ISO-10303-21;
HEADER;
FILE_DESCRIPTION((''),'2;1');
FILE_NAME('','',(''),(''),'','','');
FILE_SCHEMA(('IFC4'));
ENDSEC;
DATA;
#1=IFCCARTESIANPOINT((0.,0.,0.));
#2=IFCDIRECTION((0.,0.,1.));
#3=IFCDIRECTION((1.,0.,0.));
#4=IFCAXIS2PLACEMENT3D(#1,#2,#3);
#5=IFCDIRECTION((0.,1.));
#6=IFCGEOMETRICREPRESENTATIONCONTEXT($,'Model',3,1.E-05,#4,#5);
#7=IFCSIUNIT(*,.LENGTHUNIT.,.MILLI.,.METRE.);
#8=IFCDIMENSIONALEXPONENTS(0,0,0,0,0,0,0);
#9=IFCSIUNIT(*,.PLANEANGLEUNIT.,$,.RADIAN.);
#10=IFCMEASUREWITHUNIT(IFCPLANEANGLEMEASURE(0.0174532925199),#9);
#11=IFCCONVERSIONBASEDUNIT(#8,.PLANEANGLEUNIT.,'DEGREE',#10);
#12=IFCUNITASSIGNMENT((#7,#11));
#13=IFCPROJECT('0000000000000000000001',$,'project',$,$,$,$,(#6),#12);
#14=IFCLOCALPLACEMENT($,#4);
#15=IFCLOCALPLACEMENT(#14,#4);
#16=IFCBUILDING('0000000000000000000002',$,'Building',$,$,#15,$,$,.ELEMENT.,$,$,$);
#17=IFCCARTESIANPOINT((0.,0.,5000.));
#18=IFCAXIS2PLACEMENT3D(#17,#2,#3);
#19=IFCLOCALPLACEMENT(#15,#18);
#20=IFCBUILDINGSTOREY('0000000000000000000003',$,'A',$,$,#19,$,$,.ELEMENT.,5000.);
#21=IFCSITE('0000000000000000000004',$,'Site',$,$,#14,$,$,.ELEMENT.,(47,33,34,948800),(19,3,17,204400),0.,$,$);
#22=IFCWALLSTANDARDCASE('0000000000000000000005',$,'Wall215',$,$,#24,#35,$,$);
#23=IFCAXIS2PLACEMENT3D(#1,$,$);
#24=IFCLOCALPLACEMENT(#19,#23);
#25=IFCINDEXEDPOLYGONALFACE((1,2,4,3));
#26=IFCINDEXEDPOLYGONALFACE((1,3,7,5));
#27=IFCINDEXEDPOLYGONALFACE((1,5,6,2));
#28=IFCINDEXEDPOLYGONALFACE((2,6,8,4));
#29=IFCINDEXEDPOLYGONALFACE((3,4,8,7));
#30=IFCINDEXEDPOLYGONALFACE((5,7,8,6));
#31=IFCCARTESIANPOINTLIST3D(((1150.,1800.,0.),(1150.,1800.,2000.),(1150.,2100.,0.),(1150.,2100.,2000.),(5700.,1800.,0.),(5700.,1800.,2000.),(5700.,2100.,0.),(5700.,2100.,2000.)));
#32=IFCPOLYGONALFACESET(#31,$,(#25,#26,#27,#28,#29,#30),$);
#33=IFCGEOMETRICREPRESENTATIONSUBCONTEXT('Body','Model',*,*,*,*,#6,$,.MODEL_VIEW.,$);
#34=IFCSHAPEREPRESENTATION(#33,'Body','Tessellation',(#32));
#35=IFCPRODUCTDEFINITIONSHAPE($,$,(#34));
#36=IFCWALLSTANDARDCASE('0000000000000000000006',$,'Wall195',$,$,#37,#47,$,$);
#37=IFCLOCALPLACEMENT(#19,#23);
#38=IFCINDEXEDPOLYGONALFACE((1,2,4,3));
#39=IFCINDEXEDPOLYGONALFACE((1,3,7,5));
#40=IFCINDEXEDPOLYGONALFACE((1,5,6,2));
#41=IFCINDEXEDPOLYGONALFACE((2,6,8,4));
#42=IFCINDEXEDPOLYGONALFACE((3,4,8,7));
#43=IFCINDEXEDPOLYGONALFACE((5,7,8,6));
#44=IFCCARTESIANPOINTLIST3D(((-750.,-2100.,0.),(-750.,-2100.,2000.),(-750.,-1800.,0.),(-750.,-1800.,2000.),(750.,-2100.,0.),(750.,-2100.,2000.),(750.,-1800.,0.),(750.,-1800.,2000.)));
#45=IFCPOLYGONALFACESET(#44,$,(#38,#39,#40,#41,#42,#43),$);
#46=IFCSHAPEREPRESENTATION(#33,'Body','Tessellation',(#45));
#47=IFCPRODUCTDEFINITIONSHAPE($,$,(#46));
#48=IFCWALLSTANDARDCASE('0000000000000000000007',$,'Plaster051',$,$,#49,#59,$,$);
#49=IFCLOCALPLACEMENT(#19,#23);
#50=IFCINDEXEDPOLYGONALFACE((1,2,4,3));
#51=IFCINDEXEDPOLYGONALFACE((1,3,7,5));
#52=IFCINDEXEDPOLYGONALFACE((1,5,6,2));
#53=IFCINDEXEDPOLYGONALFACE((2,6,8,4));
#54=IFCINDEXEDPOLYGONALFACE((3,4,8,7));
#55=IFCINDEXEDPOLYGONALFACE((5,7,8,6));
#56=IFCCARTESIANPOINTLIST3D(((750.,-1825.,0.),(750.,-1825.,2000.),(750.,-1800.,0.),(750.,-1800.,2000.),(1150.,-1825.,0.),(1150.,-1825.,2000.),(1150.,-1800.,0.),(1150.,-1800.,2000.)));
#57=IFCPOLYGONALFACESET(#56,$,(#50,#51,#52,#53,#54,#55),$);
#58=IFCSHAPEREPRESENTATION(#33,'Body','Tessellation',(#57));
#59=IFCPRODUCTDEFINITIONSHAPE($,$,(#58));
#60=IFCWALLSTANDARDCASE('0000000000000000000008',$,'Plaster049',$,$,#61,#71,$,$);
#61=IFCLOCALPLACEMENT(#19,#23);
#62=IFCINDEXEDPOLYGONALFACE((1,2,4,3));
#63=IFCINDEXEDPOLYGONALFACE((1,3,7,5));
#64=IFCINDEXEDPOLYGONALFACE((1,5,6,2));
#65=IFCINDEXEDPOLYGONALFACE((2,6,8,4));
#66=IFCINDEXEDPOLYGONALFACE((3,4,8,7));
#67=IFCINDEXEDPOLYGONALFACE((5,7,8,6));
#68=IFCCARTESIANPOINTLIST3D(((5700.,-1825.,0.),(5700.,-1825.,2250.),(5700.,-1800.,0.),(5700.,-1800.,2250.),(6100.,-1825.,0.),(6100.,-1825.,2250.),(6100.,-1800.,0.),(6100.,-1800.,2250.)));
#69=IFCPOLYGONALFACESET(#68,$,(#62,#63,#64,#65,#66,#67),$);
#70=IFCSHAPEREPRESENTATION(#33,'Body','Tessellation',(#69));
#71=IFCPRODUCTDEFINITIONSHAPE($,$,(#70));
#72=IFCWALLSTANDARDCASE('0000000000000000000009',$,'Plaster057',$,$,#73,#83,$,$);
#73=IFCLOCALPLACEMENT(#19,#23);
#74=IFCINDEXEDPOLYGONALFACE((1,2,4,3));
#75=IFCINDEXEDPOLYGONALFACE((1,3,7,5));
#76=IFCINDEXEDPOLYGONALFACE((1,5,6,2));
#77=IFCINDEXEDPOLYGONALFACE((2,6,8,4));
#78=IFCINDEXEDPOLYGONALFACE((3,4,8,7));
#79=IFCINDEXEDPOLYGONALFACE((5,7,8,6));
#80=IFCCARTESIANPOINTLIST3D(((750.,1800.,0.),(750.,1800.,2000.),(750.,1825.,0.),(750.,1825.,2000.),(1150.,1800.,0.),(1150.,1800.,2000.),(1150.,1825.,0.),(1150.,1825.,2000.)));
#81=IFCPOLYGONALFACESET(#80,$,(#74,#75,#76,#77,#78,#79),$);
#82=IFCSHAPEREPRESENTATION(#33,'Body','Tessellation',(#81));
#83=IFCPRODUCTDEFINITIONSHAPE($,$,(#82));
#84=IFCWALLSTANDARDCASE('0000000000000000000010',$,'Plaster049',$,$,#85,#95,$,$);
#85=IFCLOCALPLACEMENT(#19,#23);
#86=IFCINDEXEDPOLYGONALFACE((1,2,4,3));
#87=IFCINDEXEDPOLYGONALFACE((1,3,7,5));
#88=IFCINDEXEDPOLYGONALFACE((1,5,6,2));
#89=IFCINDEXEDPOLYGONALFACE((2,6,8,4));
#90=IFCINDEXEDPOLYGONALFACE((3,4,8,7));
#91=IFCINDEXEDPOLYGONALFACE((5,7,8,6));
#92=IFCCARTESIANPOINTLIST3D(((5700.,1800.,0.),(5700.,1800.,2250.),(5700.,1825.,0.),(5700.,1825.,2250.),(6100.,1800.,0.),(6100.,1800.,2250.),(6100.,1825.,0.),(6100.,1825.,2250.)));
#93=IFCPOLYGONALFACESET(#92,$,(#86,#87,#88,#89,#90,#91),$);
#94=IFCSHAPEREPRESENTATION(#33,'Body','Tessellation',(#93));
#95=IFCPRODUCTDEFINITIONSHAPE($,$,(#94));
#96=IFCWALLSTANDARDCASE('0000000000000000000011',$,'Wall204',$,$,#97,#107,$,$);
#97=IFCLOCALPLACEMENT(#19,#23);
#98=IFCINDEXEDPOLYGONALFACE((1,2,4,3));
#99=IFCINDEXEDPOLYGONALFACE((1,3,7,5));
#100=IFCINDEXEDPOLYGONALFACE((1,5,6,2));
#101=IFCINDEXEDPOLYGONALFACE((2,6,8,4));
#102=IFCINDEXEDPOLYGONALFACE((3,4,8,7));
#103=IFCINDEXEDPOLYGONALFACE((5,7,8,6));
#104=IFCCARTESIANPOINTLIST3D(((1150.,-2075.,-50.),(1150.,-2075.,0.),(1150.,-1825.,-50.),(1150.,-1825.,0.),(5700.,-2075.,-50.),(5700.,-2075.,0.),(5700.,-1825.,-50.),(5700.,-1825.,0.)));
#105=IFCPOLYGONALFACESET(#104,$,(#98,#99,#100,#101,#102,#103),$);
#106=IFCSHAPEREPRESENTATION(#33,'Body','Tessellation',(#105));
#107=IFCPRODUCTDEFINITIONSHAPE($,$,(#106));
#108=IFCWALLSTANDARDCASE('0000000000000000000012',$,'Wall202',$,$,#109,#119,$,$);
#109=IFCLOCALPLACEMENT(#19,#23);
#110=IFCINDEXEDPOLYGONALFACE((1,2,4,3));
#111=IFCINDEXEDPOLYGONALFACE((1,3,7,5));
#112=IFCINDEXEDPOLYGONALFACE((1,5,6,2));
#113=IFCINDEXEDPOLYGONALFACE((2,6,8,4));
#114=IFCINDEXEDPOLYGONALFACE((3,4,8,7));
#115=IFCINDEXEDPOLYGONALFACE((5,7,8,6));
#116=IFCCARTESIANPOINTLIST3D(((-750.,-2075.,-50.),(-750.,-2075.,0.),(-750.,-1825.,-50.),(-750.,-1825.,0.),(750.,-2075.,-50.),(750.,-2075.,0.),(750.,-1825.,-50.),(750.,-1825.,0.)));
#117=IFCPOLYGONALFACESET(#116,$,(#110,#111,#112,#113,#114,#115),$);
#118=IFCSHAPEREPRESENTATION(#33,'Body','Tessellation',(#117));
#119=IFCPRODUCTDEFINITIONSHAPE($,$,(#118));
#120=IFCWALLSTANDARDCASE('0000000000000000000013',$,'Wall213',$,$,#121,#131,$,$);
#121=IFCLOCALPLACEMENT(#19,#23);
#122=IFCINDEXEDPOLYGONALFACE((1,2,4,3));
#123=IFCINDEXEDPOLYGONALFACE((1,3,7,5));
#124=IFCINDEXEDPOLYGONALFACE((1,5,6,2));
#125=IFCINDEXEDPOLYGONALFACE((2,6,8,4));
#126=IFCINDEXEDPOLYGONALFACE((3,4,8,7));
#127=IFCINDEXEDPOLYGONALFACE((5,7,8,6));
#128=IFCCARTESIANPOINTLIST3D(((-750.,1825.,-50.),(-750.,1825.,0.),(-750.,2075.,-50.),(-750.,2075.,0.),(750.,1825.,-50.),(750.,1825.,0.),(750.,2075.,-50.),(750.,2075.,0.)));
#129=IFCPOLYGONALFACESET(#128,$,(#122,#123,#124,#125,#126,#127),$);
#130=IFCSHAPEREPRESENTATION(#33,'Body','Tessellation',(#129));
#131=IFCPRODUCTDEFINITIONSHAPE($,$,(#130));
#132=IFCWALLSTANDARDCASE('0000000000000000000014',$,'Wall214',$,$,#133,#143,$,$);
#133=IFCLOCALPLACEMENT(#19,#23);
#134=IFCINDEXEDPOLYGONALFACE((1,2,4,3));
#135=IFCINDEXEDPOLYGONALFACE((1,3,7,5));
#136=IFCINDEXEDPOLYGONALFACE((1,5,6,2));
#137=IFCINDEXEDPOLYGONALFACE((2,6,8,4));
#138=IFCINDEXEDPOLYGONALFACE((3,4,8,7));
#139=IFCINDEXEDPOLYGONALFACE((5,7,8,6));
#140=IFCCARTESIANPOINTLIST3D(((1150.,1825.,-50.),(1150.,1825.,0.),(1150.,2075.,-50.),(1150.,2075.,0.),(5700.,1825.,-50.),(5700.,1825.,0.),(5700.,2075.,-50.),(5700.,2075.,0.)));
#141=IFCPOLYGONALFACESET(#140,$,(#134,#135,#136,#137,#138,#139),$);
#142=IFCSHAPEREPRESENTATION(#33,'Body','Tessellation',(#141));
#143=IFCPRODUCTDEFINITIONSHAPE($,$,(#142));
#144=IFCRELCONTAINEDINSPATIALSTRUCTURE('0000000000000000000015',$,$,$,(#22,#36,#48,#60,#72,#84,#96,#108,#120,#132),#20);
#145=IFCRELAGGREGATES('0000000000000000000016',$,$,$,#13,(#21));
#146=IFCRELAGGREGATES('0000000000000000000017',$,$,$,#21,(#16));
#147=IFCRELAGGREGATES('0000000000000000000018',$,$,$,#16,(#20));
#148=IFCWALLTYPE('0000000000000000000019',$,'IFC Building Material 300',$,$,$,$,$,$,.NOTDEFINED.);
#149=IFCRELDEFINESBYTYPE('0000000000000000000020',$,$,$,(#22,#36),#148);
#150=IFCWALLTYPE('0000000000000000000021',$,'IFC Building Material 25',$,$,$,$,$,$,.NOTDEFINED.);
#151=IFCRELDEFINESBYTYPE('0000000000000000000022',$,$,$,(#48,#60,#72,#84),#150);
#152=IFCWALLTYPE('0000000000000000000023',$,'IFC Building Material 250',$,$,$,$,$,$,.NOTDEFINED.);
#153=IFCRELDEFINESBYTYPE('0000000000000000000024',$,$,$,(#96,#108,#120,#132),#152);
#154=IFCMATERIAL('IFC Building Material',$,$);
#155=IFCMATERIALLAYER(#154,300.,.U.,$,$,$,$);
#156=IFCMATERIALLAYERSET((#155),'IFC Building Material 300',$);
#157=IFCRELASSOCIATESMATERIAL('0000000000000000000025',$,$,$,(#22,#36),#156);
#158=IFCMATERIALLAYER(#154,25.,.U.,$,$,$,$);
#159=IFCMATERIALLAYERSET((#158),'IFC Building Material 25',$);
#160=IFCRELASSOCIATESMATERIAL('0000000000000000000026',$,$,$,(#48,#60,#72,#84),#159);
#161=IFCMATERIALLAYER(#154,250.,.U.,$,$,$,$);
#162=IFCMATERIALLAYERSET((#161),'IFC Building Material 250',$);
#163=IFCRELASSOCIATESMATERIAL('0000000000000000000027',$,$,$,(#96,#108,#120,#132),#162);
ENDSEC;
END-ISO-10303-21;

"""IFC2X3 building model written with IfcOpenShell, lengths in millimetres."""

from ifc_helpers import new_model, entity, si_unit, converted_unit, direction, frame, origin_with_axes, place, context, subcontext, project, spatial, polyline, outline, extrude, material, layer, layer_set, layer_usage, type_object, element, save


model = new_model("IFC2X3")

# Units and contexts
model_context = context("Model", 3, precision=1e-05, world=origin_with_axes(), true_north=direction((0.0, 1.0)))
body_context = subcontext(model_context, "Body", "Model", "MODEL_VIEW")
ifc_project = project(units=[si_unit("LENGTHUNIT", "METRE", prefix="MILLI"), converted_unit("PLANEANGLEUNIT", "DEGREE", entity("IfcPlaneAngleMeasure", 0.0174532925199), si_unit("PLANEANGLEUNIT", "RADIAN"), dimensions=[0, 0, 0, 0, 0, 0, 0])], contexts=[model_context])

# Site, building, storey
site_placement = place(None, origin_with_axes())
site = spatial("IfcSite", under=ifc_project, at=site_placement, Name="Site", CompositionType="ELEMENT", RefLatitude=(47, 33, 34, 948800), RefLongitude=(19, 3, 17, 204400), RefElevation=0.0)
building_placement = place(site_placement, origin_with_axes())
building = spatial("IfcBuilding", under=site, at=building_placement, Name="Building", CompositionType="ELEMENT")
storey_placement = place(building_placement, frame((0.0, 0.0, 5000.0), z_axis=(0.0, 0.0, 1.0), x_axis=(1.0, 0.0, 0.0)))
storey = spatial("IfcBuildingStorey", under=building, at=storey_placement, Name="A", CompositionType="ELEMENT", Elevation=5000.0)

# Shared definitions
ifc_material = material(Name="IFC Building Material")

# Shared definitions
ifc_layer_1 = layer(ifc_material, 250.0, ventilated="UNKNOWN")
ifc_layer_set_1 = layer_set([ifc_layer_1], Name="IFC Building Material 250")
ifc_layer_2 = layer(ifc_material, 25.0, ventilated="UNKNOWN")
ifc_layer_set_2 = layer_set([ifc_layer_2], Name="IFC Building Material 25")

# Walls
ifc_layer_3 = layer(ifc_material, 300.0, ventilated="UNKNOWN")
ifc_layer_set_3 = layer_set([ifc_layer_3], Name="IFC Building Material 300")
wall_type_1 = type_object("IfcWallType", Name="IFC Building Material 300", PredefinedType="NOTDEFINED")
ifc_layer_usage_1 = layer_usage(ifc_layer_set_3, "AXIS2", "POSITIVE", -300.0)
wall_1_placement = place(storey_placement, frame((5700.0, 1800.0, 0.0), z_axis=(0.0, 0.0, 1.0), x_axis=(-1.0, 0.0, 0.0)))
element("IfcWallStandardCase", 1, at=wall_1_placement, inside=storey, type_object=wall_type_1, material=ifc_layer_usage_1, Name="Wall215", context=body_context, shape_type="SweptSolid", body=[
    extrude(outline(polyline([(0.0, -300.0), (4550.0, -300.0), (4550.0, 0.0), (0.0, 0.0), (0.0, -300.0)])), origin_with_axes(), (0.0, 0.0, 1.0), 2000.0),
])
ifc_layer_usage_2 = layer_usage(ifc_layer_set_3, "AXIS2", "POSITIVE", -300.0)
wall_2_placement = place(storey_placement, frame((-750.0, -1800.0, 0.0), z_axis=(0.0, 0.0, 1.0), x_axis=(1.0, 0.0, 0.0)))
element("IfcWallStandardCase", 2, at=wall_2_placement, inside=storey, type_object=wall_type_1, material=ifc_layer_usage_2, Name="Wall195", context=body_context, shape_type="SweptSolid", body=[
    extrude(outline(polyline([(0.0, -300.0), (1500.0, -300.0), (1500.0, 0.0), (0.0, 0.0), (0.0, -300.0)])), origin_with_axes(), (0.0, 0.0, 1.0), 2000.0),
])
ifc_layer_usage_3 = layer_usage(ifc_layer_set_2, "AXIS2", "POSITIVE", -25.0)
wall_type_2 = type_object("IfcWallType", Name="IFC Building Material 25", PredefinedType="NOTDEFINED")
wall_3_placement = place(storey_placement, frame((750.0, -1800.0, 0.0), z_axis=(0.0, 0.0, 1.0), x_axis=(1.0, 0.0, 0.0)))
element("IfcWallStandardCase", 3, at=wall_3_placement, inside=storey, type_object=wall_type_2, material=ifc_layer_usage_3, Name="Plaster051", context=body_context, shape_type="SweptSolid", body=[
    extrude(outline(polyline([(0.0, -25.0), (400.0, -25.0), (400.0, 0.0), (0.0, 0.0), (0.0, -25.0)])), origin_with_axes(), (0.0, 0.0, 1.0), 2000.0),
])
ifc_layer_usage_4 = layer_usage(ifc_layer_set_2, "AXIS2", "POSITIVE", -25.0)
wall_4_placement = place(storey_placement, frame((5700.0, -1800.0, 0.0), z_axis=(0.0, 0.0, 1.0), x_axis=(1.0, 0.0, 0.0)))
element("IfcWallStandardCase", 4, at=wall_4_placement, inside=storey, type_object=wall_type_2, material=ifc_layer_usage_4, Name="Plaster049", context=body_context, shape_type="SweptSolid", body=[
    extrude(outline(polyline([(0.0, -25.0), (400.0, -25.0), (400.0, 0.0), (0.0, 0.0), (0.0, -25.0)])), origin_with_axes(), (0.0, 0.0, 1.0), 2250.0),
])
ifc_layer_usage_5 = layer_usage(ifc_layer_set_2, "AXIS2", "POSITIVE", 0.0)
wall_5_placement = place(storey_placement, frame((750.0, 1800.0, 0.0), z_axis=(0.0, 0.0, 1.0), x_axis=(1.0, 0.0, 0.0)))
element("IfcWallStandardCase", 5, at=wall_5_placement, inside=storey, type_object=wall_type_2, material=ifc_layer_usage_5, Name="Plaster057", context=body_context, shape_type="SweptSolid", body=[
    extrude(outline(polyline([(0.0, 0.0), (400.0, 0.0), (400.0, 25.0), (0.0, 25.0), (0.0, 0.0)])), origin_with_axes(), (0.0, 0.0, 1.0), 2000.0),
])
ifc_layer_usage_6 = layer_usage(ifc_layer_set_2, "AXIS2", "NEGATIVE", 25.0)
wall_6_placement = place(storey_placement, frame((5700.0, 1800.0, 0.0), z_axis=(0.0, 0.0, 1.0), x_axis=(1.0, 0.0, 0.0)))
element("IfcWallStandardCase", 6, at=wall_6_placement, inside=storey, type_object=wall_type_2, material=ifc_layer_usage_6, Name="Plaster049", context=body_context, shape_type="SweptSolid", body=[
    extrude(outline(polyline([(0.0, 0.0), (400.0, 0.0), (400.0, 25.0), (0.0, 25.0), (0.0, 0.0)])), origin_with_axes(), (0.0, 0.0, 1.0), 2250.0),
])
ifc_layer_usage_7 = layer_usage(ifc_layer_set_1, "AXIS2", "POSITIVE", 0.0)
wall_type_3 = type_object("IfcWallType", Name="IFC Building Material 250", PredefinedType="NOTDEFINED")
wall_7_placement = place(storey_placement, frame((5700.0, -1825.0, -50.0), z_axis=(0.0, 0.0, 1.0), x_axis=(-1.0, 0.0, 0.0)))
element("IfcWallStandardCase", 7, at=wall_7_placement, inside=storey, type_object=wall_type_3, material=ifc_layer_usage_7, Name="Wall204", context=body_context, shape_type="SweptSolid", body=[
    extrude(outline(polyline([(0.0, 0.0), (4550.0, 0.0), (4550.0, 250.0), (0.0, 250.0), (0.0, 0.0)])), origin_with_axes(), (0.0, 0.0, 1.0), 50.0),
])
ifc_layer_usage_8 = layer_usage(ifc_layer_set_1, "AXIS2", "POSITIVE", -250.0)
wall_8_placement = place(storey_placement, frame((-750.0, -1825.0, -50.0), z_axis=(0.0, 0.0, 1.0), x_axis=(1.0, 0.0, 0.0)))
element("IfcWallStandardCase", 8, at=wall_8_placement, inside=storey, type_object=wall_type_3, material=ifc_layer_usage_8, Name="Wall202", context=body_context, shape_type="SweptSolid", body=[
    extrude(outline(polyline([(0.0, -250.0), (1500.0, -250.0), (1500.0, 0.0), (0.0, 0.0), (0.0, -250.0)])), origin_with_axes(), (0.0, 0.0, 1.0), 50.0),
])
ifc_layer_usage_9 = layer_usage(ifc_layer_set_1, "AXIS2", "POSITIVE", 0.0)
wall_9_placement = place(storey_placement, frame((-750.0, 1825.0, -50.0), z_axis=(0.0, 0.0, 1.0), x_axis=(1.0, 0.0, 0.0)))
element("IfcWallStandardCase", 9, at=wall_9_placement, inside=storey, type_object=wall_type_3, material=ifc_layer_usage_9, Name="Wall213", context=body_context, shape_type="SweptSolid", body=[
    extrude(outline(polyline([(0.0, 0.0), (1500.0, 0.0), (1500.0, 250.0), (0.0, 250.0), (0.0, 0.0)])), origin_with_axes(), (0.0, 0.0, 1.0), 50.0),
])
ifc_layer_usage_10 = layer_usage(ifc_layer_set_1, "AXIS2", "POSITIVE", -250.0)
wall_10_placement = place(storey_placement, frame((5700.0, 1825.0, -50.0), z_axis=(0.0, 0.0, 1.0), x_axis=(-1.0, 0.0, 0.0)))
element("IfcWallStandardCase", 10, at=wall_10_placement, inside=storey, type_object=wall_type_3, material=ifc_layer_usage_10, Name="Wall214", context=body_context, shape_type="SweptSolid", body=[
    extrude(outline(polyline([(0.0, -250.0), (4550.0, -250.0), (4550.0, 0.0), (0.0, 0.0), (0.0, -250.0)])), origin_with_axes(), (0.0, 0.0, 1.0), 50.0),
])

save(model, "model.ifc")
